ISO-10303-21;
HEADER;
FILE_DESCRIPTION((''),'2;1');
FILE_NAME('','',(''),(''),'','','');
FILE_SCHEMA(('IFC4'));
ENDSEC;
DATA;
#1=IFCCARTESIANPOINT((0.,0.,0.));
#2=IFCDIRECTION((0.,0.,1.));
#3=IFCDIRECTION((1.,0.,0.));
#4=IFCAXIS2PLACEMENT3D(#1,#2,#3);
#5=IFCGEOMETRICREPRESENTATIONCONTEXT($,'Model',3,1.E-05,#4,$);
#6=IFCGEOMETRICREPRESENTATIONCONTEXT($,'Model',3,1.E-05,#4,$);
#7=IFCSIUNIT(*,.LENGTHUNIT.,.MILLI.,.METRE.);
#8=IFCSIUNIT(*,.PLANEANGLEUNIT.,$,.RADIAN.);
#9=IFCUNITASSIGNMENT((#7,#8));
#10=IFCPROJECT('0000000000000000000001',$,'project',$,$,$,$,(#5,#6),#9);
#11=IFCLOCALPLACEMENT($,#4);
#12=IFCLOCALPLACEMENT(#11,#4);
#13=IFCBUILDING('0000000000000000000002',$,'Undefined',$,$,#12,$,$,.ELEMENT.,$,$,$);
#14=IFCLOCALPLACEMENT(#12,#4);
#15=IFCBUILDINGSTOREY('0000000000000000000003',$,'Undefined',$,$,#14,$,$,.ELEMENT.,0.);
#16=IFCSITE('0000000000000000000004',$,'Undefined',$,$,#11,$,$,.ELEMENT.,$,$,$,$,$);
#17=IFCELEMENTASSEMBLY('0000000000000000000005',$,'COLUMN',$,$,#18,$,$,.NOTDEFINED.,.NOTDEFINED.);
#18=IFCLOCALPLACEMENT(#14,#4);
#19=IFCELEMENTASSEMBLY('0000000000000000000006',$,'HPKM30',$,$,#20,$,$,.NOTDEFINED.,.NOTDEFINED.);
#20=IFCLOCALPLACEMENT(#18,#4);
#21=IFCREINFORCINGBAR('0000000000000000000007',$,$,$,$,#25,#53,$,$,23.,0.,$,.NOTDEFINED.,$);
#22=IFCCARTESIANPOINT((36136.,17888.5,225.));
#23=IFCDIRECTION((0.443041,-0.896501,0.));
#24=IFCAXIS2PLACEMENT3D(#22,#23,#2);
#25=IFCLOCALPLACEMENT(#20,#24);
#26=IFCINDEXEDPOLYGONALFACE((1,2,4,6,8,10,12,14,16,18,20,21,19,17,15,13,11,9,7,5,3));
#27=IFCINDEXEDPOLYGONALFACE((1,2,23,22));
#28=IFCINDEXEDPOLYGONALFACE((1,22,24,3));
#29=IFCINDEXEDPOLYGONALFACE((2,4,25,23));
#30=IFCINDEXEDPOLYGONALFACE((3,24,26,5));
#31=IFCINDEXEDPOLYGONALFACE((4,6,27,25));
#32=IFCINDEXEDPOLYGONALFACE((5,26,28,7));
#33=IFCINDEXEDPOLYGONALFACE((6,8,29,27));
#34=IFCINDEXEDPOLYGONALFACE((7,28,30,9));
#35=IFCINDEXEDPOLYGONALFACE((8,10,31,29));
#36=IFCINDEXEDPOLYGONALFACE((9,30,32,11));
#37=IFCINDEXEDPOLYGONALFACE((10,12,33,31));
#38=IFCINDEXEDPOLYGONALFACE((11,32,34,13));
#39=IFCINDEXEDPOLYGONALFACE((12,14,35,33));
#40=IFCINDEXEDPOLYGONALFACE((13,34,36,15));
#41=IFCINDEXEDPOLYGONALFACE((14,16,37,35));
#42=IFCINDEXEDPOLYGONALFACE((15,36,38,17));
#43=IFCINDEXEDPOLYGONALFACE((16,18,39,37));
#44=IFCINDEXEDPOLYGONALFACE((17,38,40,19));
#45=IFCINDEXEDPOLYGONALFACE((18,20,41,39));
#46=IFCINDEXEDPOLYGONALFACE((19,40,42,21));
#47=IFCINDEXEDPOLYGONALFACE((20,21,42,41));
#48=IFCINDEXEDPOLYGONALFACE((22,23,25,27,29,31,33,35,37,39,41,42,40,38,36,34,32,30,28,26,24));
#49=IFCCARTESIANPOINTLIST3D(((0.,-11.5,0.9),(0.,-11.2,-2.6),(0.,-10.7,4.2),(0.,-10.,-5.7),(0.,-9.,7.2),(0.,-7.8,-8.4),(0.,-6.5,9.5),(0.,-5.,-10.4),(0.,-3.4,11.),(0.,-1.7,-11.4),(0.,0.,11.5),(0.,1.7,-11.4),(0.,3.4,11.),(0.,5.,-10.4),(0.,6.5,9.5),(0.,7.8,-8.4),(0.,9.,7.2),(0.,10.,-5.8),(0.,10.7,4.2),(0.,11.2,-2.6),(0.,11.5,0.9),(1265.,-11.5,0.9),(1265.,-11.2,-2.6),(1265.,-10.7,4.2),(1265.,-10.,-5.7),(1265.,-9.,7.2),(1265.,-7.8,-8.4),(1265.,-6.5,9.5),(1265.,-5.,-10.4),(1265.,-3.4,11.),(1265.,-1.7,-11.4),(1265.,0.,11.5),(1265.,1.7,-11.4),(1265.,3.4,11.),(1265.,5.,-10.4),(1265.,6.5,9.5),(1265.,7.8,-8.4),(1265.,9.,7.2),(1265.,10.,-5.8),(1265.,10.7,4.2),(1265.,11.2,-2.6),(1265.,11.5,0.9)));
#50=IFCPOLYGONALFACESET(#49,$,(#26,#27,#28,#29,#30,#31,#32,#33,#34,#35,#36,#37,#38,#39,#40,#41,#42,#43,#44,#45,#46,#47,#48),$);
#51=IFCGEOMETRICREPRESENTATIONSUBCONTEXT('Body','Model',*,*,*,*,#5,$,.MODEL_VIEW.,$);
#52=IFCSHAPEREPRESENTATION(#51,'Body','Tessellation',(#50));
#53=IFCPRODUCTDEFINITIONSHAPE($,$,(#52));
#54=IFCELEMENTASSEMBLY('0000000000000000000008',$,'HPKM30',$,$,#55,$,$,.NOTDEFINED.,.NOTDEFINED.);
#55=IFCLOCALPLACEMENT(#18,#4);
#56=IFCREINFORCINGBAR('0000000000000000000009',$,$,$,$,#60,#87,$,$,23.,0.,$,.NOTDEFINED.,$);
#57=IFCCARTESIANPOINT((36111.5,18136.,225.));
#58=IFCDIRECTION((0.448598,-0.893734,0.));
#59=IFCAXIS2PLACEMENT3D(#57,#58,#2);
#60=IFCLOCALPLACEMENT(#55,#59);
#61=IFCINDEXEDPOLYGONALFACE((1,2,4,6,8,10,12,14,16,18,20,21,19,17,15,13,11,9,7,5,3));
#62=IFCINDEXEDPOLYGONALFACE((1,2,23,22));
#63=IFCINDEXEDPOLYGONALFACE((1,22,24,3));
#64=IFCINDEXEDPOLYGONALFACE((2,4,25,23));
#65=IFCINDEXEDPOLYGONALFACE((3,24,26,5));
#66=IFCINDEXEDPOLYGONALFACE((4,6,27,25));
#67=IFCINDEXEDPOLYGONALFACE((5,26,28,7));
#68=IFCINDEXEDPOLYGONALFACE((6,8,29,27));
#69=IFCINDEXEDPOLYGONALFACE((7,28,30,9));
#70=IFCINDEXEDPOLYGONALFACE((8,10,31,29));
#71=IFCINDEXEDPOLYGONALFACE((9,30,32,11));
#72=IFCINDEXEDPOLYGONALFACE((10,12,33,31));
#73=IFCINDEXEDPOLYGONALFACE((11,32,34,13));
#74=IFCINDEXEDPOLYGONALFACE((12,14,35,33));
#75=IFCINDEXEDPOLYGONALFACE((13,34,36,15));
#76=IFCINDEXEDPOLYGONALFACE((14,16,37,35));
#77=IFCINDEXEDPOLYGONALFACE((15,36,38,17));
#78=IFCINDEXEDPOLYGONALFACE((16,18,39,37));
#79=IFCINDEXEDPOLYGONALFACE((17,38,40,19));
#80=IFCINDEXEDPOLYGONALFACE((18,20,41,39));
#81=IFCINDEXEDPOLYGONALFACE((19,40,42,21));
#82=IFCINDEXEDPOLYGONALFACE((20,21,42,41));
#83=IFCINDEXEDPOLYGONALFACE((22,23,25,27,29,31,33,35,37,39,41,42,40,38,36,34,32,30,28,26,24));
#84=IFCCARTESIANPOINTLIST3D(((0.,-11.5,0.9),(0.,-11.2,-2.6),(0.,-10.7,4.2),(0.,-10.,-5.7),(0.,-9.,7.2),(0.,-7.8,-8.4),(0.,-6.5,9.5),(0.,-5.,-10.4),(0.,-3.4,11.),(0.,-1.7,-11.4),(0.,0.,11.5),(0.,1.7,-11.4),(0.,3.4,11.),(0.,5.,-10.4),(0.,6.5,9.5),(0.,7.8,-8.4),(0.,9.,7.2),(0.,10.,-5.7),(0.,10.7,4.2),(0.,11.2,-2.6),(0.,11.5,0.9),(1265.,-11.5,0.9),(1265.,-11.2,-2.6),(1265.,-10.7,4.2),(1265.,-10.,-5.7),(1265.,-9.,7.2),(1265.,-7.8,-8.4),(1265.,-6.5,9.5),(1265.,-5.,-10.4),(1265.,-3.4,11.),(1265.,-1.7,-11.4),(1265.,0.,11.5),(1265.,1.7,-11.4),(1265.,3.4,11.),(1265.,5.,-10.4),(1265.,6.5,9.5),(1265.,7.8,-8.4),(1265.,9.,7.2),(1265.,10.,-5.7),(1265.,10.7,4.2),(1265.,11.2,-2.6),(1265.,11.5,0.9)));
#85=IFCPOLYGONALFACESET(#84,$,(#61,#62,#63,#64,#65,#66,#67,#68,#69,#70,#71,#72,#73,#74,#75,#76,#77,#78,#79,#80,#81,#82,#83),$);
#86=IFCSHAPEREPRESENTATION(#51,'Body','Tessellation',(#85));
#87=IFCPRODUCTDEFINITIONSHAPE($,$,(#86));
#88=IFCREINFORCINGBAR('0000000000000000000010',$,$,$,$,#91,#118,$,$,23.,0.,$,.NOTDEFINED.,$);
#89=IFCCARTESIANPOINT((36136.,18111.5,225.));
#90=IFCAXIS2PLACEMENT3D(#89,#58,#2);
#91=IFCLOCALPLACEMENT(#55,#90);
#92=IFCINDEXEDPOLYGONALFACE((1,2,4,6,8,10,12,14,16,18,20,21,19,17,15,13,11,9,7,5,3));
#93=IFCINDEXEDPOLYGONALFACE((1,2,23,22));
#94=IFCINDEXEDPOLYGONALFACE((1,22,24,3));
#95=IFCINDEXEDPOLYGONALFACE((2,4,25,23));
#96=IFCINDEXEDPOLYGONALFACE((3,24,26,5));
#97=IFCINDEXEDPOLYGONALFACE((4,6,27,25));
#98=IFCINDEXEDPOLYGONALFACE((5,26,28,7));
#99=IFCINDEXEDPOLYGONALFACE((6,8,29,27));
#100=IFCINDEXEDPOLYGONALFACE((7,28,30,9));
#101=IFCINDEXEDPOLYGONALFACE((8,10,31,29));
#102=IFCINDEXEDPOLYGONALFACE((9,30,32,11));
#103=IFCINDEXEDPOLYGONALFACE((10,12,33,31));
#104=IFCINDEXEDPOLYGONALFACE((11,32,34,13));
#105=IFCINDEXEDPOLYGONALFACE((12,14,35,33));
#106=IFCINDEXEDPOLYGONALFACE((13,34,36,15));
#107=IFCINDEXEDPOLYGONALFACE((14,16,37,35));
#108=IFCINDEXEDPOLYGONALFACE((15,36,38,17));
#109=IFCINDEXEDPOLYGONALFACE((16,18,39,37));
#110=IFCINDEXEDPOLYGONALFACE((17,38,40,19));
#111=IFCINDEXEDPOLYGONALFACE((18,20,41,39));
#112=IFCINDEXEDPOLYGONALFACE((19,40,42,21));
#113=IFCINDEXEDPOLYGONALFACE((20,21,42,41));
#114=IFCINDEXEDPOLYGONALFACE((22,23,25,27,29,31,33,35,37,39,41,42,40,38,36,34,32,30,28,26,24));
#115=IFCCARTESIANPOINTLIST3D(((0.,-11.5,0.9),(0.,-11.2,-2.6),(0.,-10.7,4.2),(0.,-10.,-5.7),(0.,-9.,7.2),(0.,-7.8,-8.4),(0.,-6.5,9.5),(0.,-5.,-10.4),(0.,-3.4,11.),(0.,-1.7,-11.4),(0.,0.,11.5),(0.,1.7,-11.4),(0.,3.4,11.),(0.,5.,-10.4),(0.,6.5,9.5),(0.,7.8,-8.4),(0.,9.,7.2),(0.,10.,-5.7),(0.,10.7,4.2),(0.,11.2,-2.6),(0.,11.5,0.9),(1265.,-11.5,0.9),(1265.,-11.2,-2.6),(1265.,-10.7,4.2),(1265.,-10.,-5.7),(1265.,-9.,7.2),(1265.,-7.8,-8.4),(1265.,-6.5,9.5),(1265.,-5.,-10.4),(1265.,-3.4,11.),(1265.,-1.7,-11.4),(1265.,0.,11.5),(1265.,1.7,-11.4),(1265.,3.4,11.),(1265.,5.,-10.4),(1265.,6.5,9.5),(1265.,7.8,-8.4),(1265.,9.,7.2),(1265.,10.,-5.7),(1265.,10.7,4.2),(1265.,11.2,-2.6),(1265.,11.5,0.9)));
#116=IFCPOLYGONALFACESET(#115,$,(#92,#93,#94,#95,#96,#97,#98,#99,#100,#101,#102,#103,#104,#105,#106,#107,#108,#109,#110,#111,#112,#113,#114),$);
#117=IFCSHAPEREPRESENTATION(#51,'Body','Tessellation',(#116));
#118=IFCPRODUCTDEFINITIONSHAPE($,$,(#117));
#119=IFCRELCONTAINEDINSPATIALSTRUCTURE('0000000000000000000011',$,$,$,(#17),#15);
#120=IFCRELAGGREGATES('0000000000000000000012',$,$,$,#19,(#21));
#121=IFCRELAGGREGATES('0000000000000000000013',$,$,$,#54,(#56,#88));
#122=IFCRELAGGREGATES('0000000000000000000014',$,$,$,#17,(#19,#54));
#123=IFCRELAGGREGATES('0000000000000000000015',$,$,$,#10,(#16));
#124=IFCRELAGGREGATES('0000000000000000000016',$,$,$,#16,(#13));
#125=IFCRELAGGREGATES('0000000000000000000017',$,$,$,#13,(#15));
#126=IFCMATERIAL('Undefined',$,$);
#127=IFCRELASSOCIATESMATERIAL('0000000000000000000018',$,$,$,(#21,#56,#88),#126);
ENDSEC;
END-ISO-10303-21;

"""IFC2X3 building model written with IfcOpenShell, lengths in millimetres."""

from ifc_helpers import new_model, entity, si_unit, frame, origin_with_axes, place, context, subcontext, project, spatial, source, transform, mapped, material, element, aggregate, save


model = new_model("IFC2X3")

# Units and contexts
model_context_1 = context("Model", 3, precision=1e-05, world=origin_with_axes())
model_context_2 = context("Model", 3, precision=1e-05, world=origin_with_axes())
body_context = subcontext(model_context_1, "Body", "Model", "MODEL_VIEW")
ifc_project = project(units=[si_unit("LENGTHUNIT", "METRE", prefix="MILLI"), si_unit("PLANEANGLEUNIT", "RADIAN")], contexts=[model_context_1, model_context_2])

# Site, building, storey
site_placement = place(None, origin_with_axes())
site = spatial("IfcSite", under=ifc_project, at=site_placement, Name="Undefined", CompositionType="ELEMENT")
building_placement = place(site_placement, origin_with_axes())
building = spatial("IfcBuilding", under=site, at=building_placement, Name="Undefined", CompositionType="ELEMENT")
storey_placement = place(building_placement, origin_with_axes())
storey = spatial("IfcBuildingStorey", under=building, at=storey_placement, Name="Undefined", CompositionType="ELEMENT", Elevation=0.0)

# Element assembly
assembly_1_placement = place(storey_placement, origin_with_axes())
assembly_1 = element("IfcElementAssembly", 1, at=assembly_1_placement, inside=storey, Name="COLUMN", AssemblyPlace="NOTDEFINED", PredefinedType="NOTDEFINED")

# Shared definitions
ifc_material_1 = material(Name="Undefined")

# Element assembly, reinforcing bar
assembly_2_placement = place(assembly_1_placement, origin_with_axes())
assembly_2 = element("IfcElementAssembly", 2, at=assembly_2_placement, Name="HPKM30", AssemblyPlace="NOTDEFINED", PredefinedType="NOTDEFINED")
shared_shape_1 = source(origin_with_axes(), body_context, "Body", "AdvancedSweptSolid", [
    entity("IfcSweptDiskSolid", entity("IfcTrimmedCurve", entity("IfcLine", entity("IfcCartesianPoint", [0.0, 0.0, 0.0]), entity("IfcVector", entity("IfcDirection", [1.0, 0.0, 0.0]), 1.0)), [entity("IfcParameterValue", 0.0)], [entity("IfcParameterValue", 1265.0)], True, "PARAMETER"), 11.5, None, 0.0, 1265.0),
])
reinforcing_bar_1_placement = place(assembly_2_placement, frame((36136.0, 17888.5, 225.0), z_axis=(0.443041, -0.896501, 0.0), x_axis=(0.0, 0.0, 1.0)))
reinforcing_bar_1 = element("IfcReinforcingBar", 3, at=reinforcing_bar_1_placement, material=ifc_material_1, BarRole="NOTDEFINED", CrossSectionArea=0.0, NominalDiameter=23.0, context=body_context, shape_type="MappedRepresentation", body=[
    mapped(shared_shape_1, transform((0.0, 0.0, 0.0))),
])
aggregate(assembly_2, [reinforcing_bar_1])

# Element assembly, reinforcing bars
assembly_3_placement = place(assembly_1_placement, origin_with_axes())
assembly_3 = element("IfcElementAssembly", 4, at=assembly_3_placement, Name="HPKM30", AssemblyPlace="NOTDEFINED", PredefinedType="NOTDEFINED")
shared_shape_2 = source(origin_with_axes(), body_context, "Body", "AdvancedSweptSolid", [
    entity("IfcSweptDiskSolid", entity("IfcTrimmedCurve", entity("IfcLine", entity("IfcCartesianPoint", [0.0, 0.0, 0.0]), entity("IfcVector", entity("IfcDirection", [1.0, 0.0, 0.0]), 1.0)), [entity("IfcParameterValue", 0.0)], [entity("IfcParameterValue", 1265.0)], True, "PARAMETER"), 11.5, None, 0.0, 1265.0),
])
reinforcing_bar_2_placement = place(assembly_3_placement, frame((36111.5, 18136.0, 225.0), z_axis=(0.448598, -0.893734, 0.0), x_axis=(0.0, 0.0, 1.0)))
reinforcing_bar_2 = element("IfcReinforcingBar", 5, at=reinforcing_bar_2_placement, material=ifc_material_1, BarRole="NOTDEFINED", CrossSectionArea=0.0, NominalDiameter=23.0, context=body_context, shape_type="MappedRepresentation", body=[
    mapped(shared_shape_2, transform((0.0, 0.0, 0.0))),
])
shared_shape_3 = source(origin_with_axes(), body_context, "Body", "AdvancedSweptSolid", [
    entity("IfcSweptDiskSolid", entity("IfcTrimmedCurve", entity("IfcLine", entity("IfcCartesianPoint", [0.0, 0.0, 0.0]), entity("IfcVector", entity("IfcDirection", [1.0, 0.0, 0.0]), 1.0)), [entity("IfcParameterValue", 0.0)], [entity("IfcParameterValue", 1265.0)], True, "PARAMETER"), 11.5, None, 0.0, 1265.0),
])
reinforcing_bar_3_placement = place(assembly_3_placement, frame((36136.0, 18111.5, 225.0), z_axis=(0.448598, -0.893734, 0.0), x_axis=(0.0, 0.0, 1.0)))
reinforcing_bar_3 = element("IfcReinforcingBar", 6, at=reinforcing_bar_3_placement, material=ifc_material_1, BarRole="NOTDEFINED", CrossSectionArea=0.0, NominalDiameter=23.0, context=body_context, shape_type="MappedRepresentation", body=[
    mapped(shared_shape_3, transform((0.0, 0.0, 0.0))),
])
aggregate(assembly_3, [reinforcing_bar_2, reinforcing_bar_3])

aggregate(assembly_1, [assembly_2, assembly_3])

save(model, "model.ifc")
